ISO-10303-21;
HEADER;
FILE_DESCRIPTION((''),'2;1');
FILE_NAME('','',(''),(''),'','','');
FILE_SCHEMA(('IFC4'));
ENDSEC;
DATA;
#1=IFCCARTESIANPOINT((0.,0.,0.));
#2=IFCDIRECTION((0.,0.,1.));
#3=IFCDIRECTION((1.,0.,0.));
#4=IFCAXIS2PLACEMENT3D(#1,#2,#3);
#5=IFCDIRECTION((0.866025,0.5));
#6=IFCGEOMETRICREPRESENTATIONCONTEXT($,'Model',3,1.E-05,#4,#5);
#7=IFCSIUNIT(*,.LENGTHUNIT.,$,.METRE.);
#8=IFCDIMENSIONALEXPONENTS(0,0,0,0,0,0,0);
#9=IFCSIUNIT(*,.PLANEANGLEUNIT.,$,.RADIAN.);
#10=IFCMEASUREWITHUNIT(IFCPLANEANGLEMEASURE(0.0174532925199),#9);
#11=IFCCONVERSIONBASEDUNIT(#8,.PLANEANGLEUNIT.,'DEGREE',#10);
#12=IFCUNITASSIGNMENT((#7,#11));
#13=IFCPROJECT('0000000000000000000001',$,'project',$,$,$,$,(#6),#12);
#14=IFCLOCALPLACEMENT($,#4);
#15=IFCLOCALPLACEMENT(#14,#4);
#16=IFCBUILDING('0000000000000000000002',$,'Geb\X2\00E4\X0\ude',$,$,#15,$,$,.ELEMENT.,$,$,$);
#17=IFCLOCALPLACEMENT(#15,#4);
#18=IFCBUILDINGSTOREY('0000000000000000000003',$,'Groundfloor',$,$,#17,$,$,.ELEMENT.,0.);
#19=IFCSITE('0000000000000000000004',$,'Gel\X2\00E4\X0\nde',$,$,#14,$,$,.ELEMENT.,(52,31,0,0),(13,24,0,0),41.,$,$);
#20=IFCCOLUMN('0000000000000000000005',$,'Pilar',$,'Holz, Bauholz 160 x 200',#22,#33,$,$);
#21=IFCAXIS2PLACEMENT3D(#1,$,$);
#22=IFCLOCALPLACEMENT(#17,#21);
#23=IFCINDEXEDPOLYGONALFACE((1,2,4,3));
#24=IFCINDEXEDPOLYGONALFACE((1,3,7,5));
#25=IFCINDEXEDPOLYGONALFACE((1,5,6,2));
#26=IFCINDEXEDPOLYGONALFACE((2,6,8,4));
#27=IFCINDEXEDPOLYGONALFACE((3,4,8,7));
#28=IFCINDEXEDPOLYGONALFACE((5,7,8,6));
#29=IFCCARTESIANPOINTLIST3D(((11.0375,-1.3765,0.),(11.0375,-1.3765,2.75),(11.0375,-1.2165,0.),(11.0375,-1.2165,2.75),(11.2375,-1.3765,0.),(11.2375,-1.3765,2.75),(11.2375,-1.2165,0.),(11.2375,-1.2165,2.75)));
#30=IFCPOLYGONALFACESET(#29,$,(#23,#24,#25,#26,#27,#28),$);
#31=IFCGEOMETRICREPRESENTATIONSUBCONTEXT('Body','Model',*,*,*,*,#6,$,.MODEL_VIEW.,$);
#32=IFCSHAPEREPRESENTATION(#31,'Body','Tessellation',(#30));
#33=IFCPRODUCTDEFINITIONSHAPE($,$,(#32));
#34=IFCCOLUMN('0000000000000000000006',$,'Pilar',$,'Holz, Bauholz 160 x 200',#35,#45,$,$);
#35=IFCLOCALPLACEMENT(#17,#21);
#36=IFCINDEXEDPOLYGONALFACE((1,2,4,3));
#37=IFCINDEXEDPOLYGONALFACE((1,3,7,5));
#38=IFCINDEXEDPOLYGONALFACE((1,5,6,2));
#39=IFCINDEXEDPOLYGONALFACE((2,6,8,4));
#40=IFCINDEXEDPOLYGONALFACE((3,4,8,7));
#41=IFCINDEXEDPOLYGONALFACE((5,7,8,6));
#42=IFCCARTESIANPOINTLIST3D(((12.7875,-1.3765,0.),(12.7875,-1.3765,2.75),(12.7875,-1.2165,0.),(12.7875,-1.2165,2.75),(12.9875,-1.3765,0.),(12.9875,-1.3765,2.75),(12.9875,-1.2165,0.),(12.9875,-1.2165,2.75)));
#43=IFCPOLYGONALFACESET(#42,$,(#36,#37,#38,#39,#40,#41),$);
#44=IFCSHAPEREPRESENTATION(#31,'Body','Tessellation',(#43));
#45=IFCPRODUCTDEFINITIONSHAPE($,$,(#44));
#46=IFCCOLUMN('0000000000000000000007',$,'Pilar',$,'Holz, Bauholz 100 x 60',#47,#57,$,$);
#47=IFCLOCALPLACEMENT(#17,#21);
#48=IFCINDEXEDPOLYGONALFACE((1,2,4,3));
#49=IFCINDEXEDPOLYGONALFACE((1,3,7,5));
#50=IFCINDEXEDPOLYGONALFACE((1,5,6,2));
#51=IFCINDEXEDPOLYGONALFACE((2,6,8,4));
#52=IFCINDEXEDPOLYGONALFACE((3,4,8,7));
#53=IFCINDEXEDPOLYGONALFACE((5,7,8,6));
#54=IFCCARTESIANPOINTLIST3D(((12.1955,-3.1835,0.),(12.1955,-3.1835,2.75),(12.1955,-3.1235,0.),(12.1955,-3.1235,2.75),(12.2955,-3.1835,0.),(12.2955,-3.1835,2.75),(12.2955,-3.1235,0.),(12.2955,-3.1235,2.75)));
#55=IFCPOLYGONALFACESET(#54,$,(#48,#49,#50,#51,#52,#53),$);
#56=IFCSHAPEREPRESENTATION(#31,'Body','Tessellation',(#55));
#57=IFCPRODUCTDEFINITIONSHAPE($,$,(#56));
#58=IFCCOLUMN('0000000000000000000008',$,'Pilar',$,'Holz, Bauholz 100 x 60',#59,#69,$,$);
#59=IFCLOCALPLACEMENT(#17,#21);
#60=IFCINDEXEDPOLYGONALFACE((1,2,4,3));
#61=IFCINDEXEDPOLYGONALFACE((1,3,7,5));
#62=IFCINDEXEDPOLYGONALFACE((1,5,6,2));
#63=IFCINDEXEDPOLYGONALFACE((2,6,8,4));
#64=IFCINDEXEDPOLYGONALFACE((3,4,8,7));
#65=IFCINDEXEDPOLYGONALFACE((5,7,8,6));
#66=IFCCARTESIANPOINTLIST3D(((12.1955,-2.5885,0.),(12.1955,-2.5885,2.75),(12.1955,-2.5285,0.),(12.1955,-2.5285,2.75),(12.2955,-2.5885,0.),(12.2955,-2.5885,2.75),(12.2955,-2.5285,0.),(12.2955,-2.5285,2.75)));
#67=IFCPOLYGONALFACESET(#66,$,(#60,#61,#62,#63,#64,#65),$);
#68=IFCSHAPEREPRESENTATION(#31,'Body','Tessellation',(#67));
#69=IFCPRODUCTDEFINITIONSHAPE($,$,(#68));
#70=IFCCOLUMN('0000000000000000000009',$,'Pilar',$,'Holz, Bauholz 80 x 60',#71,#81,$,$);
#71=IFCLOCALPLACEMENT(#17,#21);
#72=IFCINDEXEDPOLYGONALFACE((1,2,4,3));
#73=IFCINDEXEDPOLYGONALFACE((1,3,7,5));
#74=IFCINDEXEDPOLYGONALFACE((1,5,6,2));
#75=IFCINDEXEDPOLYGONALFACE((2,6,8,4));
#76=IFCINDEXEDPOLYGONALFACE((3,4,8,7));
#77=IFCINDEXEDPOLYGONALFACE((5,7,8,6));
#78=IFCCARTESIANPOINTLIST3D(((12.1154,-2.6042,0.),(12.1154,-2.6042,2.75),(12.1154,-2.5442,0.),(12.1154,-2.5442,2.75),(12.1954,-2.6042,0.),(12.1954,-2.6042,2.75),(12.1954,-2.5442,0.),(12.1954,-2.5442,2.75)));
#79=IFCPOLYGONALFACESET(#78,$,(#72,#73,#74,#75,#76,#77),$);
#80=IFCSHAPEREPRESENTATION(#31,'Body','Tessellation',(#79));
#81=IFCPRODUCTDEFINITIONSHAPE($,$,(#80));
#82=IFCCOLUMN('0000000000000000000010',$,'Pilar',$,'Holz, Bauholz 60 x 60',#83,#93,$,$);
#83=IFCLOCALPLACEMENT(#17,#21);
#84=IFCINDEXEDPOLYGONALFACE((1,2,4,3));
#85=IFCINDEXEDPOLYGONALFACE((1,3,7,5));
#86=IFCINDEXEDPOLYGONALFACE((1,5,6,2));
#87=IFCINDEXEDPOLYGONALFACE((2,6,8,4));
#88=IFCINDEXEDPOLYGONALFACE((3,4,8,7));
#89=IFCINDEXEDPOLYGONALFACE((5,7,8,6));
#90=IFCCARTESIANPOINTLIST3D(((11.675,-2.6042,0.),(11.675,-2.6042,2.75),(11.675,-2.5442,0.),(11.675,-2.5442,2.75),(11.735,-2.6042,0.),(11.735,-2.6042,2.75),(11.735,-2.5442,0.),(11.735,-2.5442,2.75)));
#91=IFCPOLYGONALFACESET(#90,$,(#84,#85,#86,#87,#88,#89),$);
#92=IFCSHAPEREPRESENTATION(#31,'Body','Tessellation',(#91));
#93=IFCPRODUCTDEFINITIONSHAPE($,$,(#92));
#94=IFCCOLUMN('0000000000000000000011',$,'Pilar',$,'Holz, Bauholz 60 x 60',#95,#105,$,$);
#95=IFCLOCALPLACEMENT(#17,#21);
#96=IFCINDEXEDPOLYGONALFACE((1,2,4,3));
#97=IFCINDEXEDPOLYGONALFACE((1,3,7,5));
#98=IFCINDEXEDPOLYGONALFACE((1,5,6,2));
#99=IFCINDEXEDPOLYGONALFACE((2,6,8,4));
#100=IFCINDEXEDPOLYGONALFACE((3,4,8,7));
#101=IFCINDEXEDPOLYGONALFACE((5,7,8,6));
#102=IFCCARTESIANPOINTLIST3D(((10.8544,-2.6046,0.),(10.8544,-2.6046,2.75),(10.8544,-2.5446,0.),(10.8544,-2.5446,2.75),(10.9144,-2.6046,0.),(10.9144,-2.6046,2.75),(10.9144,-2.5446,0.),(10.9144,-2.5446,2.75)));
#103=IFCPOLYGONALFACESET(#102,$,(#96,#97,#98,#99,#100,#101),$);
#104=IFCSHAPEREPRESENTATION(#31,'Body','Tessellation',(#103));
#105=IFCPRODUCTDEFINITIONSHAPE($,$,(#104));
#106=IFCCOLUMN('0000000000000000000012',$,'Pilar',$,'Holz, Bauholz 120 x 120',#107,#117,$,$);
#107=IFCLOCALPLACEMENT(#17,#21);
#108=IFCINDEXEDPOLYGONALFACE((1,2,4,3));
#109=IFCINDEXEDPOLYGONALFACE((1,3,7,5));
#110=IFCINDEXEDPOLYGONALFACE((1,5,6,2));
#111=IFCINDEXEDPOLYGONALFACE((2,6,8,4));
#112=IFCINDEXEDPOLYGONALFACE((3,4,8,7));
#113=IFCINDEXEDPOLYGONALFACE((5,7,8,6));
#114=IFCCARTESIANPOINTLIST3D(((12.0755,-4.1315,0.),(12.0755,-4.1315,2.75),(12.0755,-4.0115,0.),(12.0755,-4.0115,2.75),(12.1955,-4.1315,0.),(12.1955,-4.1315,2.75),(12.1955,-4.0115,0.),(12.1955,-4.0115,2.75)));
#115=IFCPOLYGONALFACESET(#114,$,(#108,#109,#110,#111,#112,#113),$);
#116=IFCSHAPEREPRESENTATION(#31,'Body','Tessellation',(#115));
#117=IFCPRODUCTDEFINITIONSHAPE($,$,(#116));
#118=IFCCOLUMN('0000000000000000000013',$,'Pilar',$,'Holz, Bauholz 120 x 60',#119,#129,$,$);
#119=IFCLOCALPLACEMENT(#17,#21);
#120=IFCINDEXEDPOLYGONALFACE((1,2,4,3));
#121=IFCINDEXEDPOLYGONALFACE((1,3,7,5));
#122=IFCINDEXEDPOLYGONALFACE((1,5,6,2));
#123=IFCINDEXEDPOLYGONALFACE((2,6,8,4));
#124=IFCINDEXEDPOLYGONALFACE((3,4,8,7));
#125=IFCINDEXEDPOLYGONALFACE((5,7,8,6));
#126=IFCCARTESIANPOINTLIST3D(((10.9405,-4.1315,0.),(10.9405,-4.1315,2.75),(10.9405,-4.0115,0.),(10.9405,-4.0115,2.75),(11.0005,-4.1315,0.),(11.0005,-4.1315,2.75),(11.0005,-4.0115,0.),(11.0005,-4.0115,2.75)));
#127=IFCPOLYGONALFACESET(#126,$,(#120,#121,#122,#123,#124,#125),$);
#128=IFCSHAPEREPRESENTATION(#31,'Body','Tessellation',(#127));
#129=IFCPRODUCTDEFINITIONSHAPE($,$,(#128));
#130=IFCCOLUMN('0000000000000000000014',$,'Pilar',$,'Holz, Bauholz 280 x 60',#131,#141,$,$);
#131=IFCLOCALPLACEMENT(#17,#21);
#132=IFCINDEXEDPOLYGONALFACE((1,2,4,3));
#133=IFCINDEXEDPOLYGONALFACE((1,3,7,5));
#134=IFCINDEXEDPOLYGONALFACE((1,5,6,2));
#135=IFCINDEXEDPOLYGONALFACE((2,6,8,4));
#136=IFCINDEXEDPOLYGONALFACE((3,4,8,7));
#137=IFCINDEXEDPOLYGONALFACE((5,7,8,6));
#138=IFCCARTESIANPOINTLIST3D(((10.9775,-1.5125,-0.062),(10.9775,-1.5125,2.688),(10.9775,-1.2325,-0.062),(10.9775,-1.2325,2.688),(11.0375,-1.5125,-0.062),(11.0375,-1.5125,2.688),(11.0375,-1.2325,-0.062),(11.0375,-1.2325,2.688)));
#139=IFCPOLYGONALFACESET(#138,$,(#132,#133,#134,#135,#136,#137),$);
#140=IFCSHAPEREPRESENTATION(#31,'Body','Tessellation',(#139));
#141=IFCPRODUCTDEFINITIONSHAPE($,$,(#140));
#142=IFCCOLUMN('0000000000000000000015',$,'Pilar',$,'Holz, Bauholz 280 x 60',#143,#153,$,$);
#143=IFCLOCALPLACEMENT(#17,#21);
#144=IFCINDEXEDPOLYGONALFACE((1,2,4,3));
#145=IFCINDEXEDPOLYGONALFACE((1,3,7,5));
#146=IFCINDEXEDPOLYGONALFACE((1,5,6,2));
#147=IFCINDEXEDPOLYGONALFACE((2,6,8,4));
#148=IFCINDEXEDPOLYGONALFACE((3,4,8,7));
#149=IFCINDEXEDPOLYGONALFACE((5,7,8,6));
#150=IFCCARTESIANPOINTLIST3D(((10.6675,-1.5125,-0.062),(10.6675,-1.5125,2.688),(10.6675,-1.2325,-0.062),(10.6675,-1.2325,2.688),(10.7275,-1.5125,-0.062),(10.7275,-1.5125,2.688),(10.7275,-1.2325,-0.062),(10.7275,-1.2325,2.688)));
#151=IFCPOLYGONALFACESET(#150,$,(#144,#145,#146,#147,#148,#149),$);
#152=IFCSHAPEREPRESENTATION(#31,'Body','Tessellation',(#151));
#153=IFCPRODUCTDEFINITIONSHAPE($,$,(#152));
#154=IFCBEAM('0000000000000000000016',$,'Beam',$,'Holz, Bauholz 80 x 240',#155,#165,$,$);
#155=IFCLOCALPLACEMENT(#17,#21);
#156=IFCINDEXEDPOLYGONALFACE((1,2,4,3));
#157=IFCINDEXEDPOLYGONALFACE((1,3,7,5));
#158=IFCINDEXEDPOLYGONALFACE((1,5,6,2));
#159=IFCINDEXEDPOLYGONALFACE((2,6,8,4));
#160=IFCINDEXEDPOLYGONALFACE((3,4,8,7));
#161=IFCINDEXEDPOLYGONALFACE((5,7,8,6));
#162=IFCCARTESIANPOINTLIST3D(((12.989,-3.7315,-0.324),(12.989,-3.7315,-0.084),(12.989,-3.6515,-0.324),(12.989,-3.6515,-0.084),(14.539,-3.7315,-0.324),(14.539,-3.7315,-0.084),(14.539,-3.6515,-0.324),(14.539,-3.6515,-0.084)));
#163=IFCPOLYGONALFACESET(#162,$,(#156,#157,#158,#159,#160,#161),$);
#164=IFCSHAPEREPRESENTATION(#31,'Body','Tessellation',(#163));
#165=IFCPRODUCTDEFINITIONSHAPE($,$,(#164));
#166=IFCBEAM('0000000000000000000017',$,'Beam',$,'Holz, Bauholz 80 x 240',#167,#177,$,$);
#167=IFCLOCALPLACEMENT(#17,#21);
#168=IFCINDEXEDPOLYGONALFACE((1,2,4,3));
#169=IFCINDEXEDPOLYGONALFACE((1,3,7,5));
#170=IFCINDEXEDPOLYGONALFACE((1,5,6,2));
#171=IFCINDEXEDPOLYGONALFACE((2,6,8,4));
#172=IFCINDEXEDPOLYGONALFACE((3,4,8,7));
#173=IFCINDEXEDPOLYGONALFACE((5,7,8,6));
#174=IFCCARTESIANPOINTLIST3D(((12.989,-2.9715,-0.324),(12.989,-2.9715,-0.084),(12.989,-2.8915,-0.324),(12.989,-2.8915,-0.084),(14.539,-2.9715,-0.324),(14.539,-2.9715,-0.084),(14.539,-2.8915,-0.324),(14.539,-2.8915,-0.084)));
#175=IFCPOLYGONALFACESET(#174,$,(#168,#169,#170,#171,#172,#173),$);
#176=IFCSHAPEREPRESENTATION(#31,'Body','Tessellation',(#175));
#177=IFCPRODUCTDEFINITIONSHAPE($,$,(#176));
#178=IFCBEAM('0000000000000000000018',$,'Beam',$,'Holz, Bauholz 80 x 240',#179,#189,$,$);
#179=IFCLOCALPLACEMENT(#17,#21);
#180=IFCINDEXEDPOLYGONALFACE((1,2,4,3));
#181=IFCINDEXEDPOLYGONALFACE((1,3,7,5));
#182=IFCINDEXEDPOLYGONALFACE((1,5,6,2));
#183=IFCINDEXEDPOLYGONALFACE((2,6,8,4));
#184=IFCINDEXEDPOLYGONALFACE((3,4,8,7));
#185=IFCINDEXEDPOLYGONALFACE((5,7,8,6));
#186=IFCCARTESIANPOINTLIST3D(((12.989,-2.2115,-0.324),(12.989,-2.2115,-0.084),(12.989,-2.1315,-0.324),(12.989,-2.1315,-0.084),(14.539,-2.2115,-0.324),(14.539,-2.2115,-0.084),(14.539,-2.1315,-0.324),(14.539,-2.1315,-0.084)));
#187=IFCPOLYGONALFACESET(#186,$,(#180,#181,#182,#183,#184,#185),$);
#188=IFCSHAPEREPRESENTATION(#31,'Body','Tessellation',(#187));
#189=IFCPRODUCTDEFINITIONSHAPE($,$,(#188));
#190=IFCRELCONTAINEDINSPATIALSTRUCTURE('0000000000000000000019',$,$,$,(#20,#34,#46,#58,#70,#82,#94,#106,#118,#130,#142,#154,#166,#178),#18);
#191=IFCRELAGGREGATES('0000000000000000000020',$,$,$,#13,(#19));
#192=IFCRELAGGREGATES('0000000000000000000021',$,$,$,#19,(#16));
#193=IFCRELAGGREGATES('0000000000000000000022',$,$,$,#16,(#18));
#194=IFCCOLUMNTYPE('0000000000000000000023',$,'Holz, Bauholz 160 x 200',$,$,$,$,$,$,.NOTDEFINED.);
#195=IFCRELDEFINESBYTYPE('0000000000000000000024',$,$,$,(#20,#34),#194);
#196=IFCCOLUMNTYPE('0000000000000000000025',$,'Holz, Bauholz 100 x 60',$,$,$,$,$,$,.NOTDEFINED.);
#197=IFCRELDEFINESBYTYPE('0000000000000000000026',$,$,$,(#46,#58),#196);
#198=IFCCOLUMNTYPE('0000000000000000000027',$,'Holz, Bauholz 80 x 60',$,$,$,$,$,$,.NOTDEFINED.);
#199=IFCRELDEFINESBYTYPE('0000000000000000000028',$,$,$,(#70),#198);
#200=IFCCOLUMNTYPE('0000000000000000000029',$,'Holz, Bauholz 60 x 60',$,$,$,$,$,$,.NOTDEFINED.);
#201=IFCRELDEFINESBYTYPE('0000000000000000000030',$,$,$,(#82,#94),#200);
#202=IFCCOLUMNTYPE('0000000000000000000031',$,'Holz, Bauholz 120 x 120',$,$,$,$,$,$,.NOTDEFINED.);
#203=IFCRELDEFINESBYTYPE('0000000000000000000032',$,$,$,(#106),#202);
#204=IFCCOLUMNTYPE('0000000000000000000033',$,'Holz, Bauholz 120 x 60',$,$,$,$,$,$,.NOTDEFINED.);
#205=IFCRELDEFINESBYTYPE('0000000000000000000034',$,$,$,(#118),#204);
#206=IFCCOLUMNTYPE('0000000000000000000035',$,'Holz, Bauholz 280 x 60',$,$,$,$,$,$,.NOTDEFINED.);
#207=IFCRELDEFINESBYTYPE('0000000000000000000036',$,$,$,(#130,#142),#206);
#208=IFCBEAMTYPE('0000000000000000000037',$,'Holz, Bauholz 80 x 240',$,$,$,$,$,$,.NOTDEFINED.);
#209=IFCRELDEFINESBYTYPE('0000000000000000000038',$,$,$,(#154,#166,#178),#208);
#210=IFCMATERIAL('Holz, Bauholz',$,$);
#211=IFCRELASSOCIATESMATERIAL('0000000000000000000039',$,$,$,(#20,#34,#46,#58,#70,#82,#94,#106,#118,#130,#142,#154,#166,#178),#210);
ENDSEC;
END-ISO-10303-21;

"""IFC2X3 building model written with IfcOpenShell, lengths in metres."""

from ifc_helpers import new_model, entity, si_unit, converted_unit, direction, frame, frame_2d, origin_with_axes, origin_2d_with_axis, place, context, subcontext, project, spatial, rectangle, extrude, clip, halfspace, material, type_object, element, save


model = new_model("IFC2X3")

# Units and contexts
model_context = context("Model", 3, precision=1e-05, world=origin_with_axes(), true_north=direction((0.866025, 0.5)))
body_context = subcontext(model_context, "Body", "Model", "MODEL_VIEW")
ifc_project = project(units=[si_unit("LENGTHUNIT", "METRE"), converted_unit("PLANEANGLEUNIT", "DEGREE", entity("IfcPlaneAngleMeasure", 0.0174532925199), si_unit("PLANEANGLEUNIT", "RADIAN"), dimensions=[0, 0, 0, 0, 0, 0, 0])], contexts=[model_context])

# Site, building, storey
site_placement = place(None, origin_with_axes())
site = spatial("IfcSite", under=ifc_project, at=site_placement, Name="Gelände", CompositionType="ELEMENT", RefLatitude=(52, 31, 0, 0), RefLongitude=(13, 24, 0, 0), RefElevation=41.0)
building_placement = place(site_placement, origin_with_axes())
building = spatial("IfcBuilding", under=site, at=building_placement, Name="Gebäude", CompositionType="ELEMENT")
storey_placement = place(building_placement, origin_with_axes())
storey = spatial("IfcBuildingStorey", under=building, at=storey_placement, Name="Groundfloor", CompositionType="ELEMENT", Elevation=0.0)

# Columns
ifc_material_1 = material(Name="Holz, Bauholz")
column_type_1 = type_object("IfcColumnType", Name="Holz, Bauholz 160 x 200", PredefinedType="NOTDEFINED")
for number, where, z_axis, x_axis, name in (
    (1, (11.1375, -1.2965, 0.0), (0.0, 0.0, 1.0), (1.0, 0.0, 0.0), "Pilar"),
    (2, (12.8875, -1.2965, 0.0), (0.0, 0.0, 1.0), (1.0, 0.0, 0.0), "Pilar"),
):
    element("IfcColumn", number, at=place(storey_placement, frame(where, z_axis=z_axis, x_axis=x_axis)), inside=storey, type_object=column_type_1, material=ifc_material_1, Name=name, ObjectType="Holz, Bauholz 160 x 200", context=body_context, shape_type="Clipping", body=[
        clip(clip(extrude(rectangle(XDim=0.16, YDim=0.2, at=origin_2d_with_axis()), frame((0.0, 0.0, 0.0), z_axis=(0.0, 0.0, 1.0), x_axis=(0.0, 1.0, 0.0)), (0.0, 0.0, 1.0), 2.75), halfspace(frame((0.0, 0.0, 2.75), z_axis=(0.0, 0.0, -1.0), x_axis=(0.0, 1.0, 0.0)), True)), halfspace(frame((0.0, 0.0, 0.0), z_axis=(0.0, 0.0, 1.0), x_axis=(0.0, -1.0, 0.0)), True)),
    ])
column_type_2 = type_object("IfcColumnType", Name="Holz, Bauholz 100 x 60", PredefinedType="NOTDEFINED")
for number, where, z_axis, x_axis, name in (
    (3, (12.2455, -3.1535, 0.0), (0.0, 0.0, 1.0), (0.0, -1.0, 0.0), "Pilar"),
    (4, (12.2455, -2.5585, 0.0), (0.0, 0.0, 1.0), (0.0, -1.0, 0.0), "Pilar"),
):
    element("IfcColumn", number, at=place(storey_placement, frame(where, z_axis=z_axis, x_axis=x_axis)), inside=storey, type_object=column_type_2, material=ifc_material_1, Name=name, ObjectType="Holz, Bauholz 100 x 60", context=body_context, shape_type="Clipping", body=[
        clip(clip(extrude(rectangle(XDim=0.1, YDim=0.06, at=origin_2d_with_axis()), frame((0.0, 0.0, 0.0), z_axis=(0.0, 0.0, 1.0), x_axis=(0.0, 1.0, 0.0)), (0.0, 0.0, 1.0), 2.75), halfspace(frame((0.0, 0.0, 2.75), z_axis=(0.0, 0.0, -1.0), x_axis=(0.0, 1.0, 0.0)), True)), halfspace(frame((0.0, 0.0, 0.0), z_axis=(0.0, 0.0, 1.0), x_axis=(0.0, -1.0, 0.0)), True)),
    ])
column_type_3 = type_object("IfcColumnType", Name="Holz, Bauholz 80 x 60", PredefinedType="NOTDEFINED")
column_1_placement = place(storey_placement, frame((12.1554, -2.5742, 0.0), z_axis=(0.0, 0.0, 1.0), x_axis=(0.0, -1.0, 0.0)))
element("IfcColumn", 5, at=column_1_placement, inside=storey, type_object=column_type_3, material=ifc_material_1, Name="Pilar", ObjectType="Holz, Bauholz 80 x 60", context=body_context, shape_type="Clipping", body=[
    clip(clip(extrude(rectangle(XDim=0.08, YDim=0.06, at=origin_2d_with_axis()), frame((0.0, 0.0, 0.0), z_axis=(0.0, 0.0, 1.0), x_axis=(0.0, 1.0, 0.0)), (0.0, 0.0, 1.0), 2.75), halfspace(frame((0.0, 0.0, 2.75), z_axis=(0.0, 0.0, -1.0), x_axis=(0.0, 1.0, 0.0)), True)), halfspace(frame((0.0, 0.0, 0.0), z_axis=(0.0, 0.0, 1.0), x_axis=(0.0, -1.0, 0.0)), True)),
])
column_type_4 = type_object("IfcColumnType", Name="Holz, Bauholz 60 x 60", PredefinedType="NOTDEFINED")
for number, where, z_axis, x_axis, name in (
    (6, (11.705, -2.5742, 0.0), (0.0, 0.0, 1.0), (0.0, -1.0, 0.0), "Pilar"),
    (7, (10.8844, -2.5746, 0.0), (0.0, 0.0, 1.0), (0.0, -1.0, 0.0), "Pilar"),
):
    element("IfcColumn", number, at=place(storey_placement, frame(where, z_axis=z_axis, x_axis=x_axis)), inside=storey, type_object=column_type_4, material=ifc_material_1, Name=name, ObjectType="Holz, Bauholz 60 x 60", context=body_context, shape_type="Clipping", body=[
        clip(clip(extrude(rectangle(XDim=0.06, YDim=0.06, at=origin_2d_with_axis()), frame((0.0, 0.0, 0.0), z_axis=(0.0, 0.0, 1.0), x_axis=(0.0, 1.0, 0.0)), (0.0, 0.0, 1.0), 2.75), halfspace(frame((0.0, 0.0, 2.75), z_axis=(0.0, 0.0, -1.0), x_axis=(0.0, 1.0, 0.0)), True)), halfspace(frame((0.0, 0.0, 0.0), z_axis=(0.0, 0.0, 1.0), x_axis=(0.0, -1.0, 0.0)), True)),
    ])
column_type_5 = type_object("IfcColumnType", Name="Holz, Bauholz 120 x 120", PredefinedType="NOTDEFINED")
column_2_placement = place(storey_placement, frame((12.1355, -4.0715, 0.0), z_axis=(0.0, 0.0, 1.0), x_axis=(1.0, 0.0, 0.0)))
element("IfcColumn", 8, at=column_2_placement, inside=storey, type_object=column_type_5, material=ifc_material_1, Name="Pilar", ObjectType="Holz, Bauholz 120 x 120", context=body_context, shape_type="Clipping", body=[
    clip(clip(extrude(rectangle(XDim=0.12, YDim=0.12, at=origin_2d_with_axis()), frame((0.0, 0.0, 0.0), z_axis=(0.0, 0.0, 1.0), x_axis=(0.0, 1.0, 0.0)), (0.0, 0.0, 1.0), 2.75), halfspace(frame((0.0, 0.0, 2.75), z_axis=(0.0, 0.0, -1.0), x_axis=(0.0, 1.0, 0.0)), True)), halfspace(frame((0.0, 0.0, 0.0), z_axis=(0.0, 0.0, 1.0), x_axis=(0.0, -1.0, 0.0)), True)),
])
column_type_6 = type_object("IfcColumnType", Name="Holz, Bauholz 120 x 60", PredefinedType="NOTDEFINED")
column_3_placement = place(storey_placement, frame((10.9705, -4.0715, 0.0), z_axis=(0.0, 0.0, 1.0), x_axis=(1.0, 0.0, 0.0)))
element("IfcColumn", 9, at=column_3_placement, inside=storey, type_object=column_type_6, material=ifc_material_1, Name="Pilar", ObjectType="Holz, Bauholz 120 x 60", context=body_context, shape_type="Clipping", body=[
    clip(clip(extrude(rectangle(XDim=0.12, YDim=0.06, at=origin_2d_with_axis()), frame((0.0, 0.0, 0.0), z_axis=(0.0, 0.0, 1.0), x_axis=(0.0, 1.0, 0.0)), (0.0, 0.0, 1.0), 2.75), halfspace(frame((0.0, 0.0, 2.75), z_axis=(0.0, 0.0, -1.0), x_axis=(0.0, 1.0, 0.0)), True)), halfspace(frame((0.0, 0.0, 0.0), z_axis=(0.0, 0.0, 1.0), x_axis=(0.0, -1.0, 0.0)), True)),
])
column_type_7 = type_object("IfcColumnType", Name="Holz, Bauholz 280 x 60", PredefinedType="NOTDEFINED")
for number, where, z_axis, x_axis, name in (
    (10, (11.0075, -1.3725, -0.062), (0.0, 0.0, 1.0), (-1.0, 0.0, 0.0), "Pilar"),
    (11, (10.6975, -1.3725, -0.062), (0.0, 0.0, 1.0), (-1.0, 0.0, 0.0), "Pilar"),
):
    element("IfcColumn", number, at=place(storey_placement, frame(where, z_axis=z_axis, x_axis=x_axis)), inside=storey, type_object=column_type_7, material=ifc_material_1, Name=name, ObjectType="Holz, Bauholz 280 x 60", context=body_context, shape_type="Clipping", body=[
        clip(clip(extrude(rectangle(XDim=0.28, YDim=0.06, at=origin_2d_with_axis()), frame((0.0, 0.0, 0.0), z_axis=(0.0, 0.0, 1.0), x_axis=(0.0, 1.0, 0.0)), (0.0, 0.0, 1.0), 2.75), halfspace(frame((0.0, 0.0, 2.75), z_axis=(0.0, 0.0, -1.0), x_axis=(0.0, 1.0, 0.0)), True)), halfspace(frame((0.0, 0.0, 0.0), z_axis=(0.0, 0.0, 1.0), x_axis=(0.0, -1.0, 0.0)), True)),
    ])

# Beams
beam_type_1 = type_object("IfcBeamType", Name="Holz, Bauholz 80 x 240", PredefinedType="NOTDEFINED")
for number, where, z_axis, x_axis, name in (
    (12, (14.539, -3.6915, -0.084), (0.0, 0.0, 1.0), (0.0, 1.0, 0.0), "Beam"),
    (13, (14.539, -2.9315, -0.084), (0.0, 0.0, 1.0), (0.0, 1.0, 0.0), "Beam"),
    (14, (14.539, -2.1715, -0.084), (0.0, 0.0, 1.0), (0.0, 1.0, 0.0), "Beam"),
):
    element("IfcBeam", number, at=place(storey_placement, frame(where, z_axis=z_axis, x_axis=x_axis)), inside=storey, type_object=beam_type_1, material=ifc_material_1, Name=name, ObjectType="Holz, Bauholz 80 x 240", context=body_context, shape_type="SweptSolid", body=[
        extrude(rectangle(XDim=0.24, YDim=0.08, at=frame_2d((-0.12, 0.0), x_axis=(1.0, 0.0))), frame((0.0, 0.0, 0.0), z_axis=(0.0, 1.0, 0.0), x_axis=(0.0, 0.0, 1.0)), (0.0, 0.0, 1.0), 1.55),
    ])

save(model, "model.ifc")
